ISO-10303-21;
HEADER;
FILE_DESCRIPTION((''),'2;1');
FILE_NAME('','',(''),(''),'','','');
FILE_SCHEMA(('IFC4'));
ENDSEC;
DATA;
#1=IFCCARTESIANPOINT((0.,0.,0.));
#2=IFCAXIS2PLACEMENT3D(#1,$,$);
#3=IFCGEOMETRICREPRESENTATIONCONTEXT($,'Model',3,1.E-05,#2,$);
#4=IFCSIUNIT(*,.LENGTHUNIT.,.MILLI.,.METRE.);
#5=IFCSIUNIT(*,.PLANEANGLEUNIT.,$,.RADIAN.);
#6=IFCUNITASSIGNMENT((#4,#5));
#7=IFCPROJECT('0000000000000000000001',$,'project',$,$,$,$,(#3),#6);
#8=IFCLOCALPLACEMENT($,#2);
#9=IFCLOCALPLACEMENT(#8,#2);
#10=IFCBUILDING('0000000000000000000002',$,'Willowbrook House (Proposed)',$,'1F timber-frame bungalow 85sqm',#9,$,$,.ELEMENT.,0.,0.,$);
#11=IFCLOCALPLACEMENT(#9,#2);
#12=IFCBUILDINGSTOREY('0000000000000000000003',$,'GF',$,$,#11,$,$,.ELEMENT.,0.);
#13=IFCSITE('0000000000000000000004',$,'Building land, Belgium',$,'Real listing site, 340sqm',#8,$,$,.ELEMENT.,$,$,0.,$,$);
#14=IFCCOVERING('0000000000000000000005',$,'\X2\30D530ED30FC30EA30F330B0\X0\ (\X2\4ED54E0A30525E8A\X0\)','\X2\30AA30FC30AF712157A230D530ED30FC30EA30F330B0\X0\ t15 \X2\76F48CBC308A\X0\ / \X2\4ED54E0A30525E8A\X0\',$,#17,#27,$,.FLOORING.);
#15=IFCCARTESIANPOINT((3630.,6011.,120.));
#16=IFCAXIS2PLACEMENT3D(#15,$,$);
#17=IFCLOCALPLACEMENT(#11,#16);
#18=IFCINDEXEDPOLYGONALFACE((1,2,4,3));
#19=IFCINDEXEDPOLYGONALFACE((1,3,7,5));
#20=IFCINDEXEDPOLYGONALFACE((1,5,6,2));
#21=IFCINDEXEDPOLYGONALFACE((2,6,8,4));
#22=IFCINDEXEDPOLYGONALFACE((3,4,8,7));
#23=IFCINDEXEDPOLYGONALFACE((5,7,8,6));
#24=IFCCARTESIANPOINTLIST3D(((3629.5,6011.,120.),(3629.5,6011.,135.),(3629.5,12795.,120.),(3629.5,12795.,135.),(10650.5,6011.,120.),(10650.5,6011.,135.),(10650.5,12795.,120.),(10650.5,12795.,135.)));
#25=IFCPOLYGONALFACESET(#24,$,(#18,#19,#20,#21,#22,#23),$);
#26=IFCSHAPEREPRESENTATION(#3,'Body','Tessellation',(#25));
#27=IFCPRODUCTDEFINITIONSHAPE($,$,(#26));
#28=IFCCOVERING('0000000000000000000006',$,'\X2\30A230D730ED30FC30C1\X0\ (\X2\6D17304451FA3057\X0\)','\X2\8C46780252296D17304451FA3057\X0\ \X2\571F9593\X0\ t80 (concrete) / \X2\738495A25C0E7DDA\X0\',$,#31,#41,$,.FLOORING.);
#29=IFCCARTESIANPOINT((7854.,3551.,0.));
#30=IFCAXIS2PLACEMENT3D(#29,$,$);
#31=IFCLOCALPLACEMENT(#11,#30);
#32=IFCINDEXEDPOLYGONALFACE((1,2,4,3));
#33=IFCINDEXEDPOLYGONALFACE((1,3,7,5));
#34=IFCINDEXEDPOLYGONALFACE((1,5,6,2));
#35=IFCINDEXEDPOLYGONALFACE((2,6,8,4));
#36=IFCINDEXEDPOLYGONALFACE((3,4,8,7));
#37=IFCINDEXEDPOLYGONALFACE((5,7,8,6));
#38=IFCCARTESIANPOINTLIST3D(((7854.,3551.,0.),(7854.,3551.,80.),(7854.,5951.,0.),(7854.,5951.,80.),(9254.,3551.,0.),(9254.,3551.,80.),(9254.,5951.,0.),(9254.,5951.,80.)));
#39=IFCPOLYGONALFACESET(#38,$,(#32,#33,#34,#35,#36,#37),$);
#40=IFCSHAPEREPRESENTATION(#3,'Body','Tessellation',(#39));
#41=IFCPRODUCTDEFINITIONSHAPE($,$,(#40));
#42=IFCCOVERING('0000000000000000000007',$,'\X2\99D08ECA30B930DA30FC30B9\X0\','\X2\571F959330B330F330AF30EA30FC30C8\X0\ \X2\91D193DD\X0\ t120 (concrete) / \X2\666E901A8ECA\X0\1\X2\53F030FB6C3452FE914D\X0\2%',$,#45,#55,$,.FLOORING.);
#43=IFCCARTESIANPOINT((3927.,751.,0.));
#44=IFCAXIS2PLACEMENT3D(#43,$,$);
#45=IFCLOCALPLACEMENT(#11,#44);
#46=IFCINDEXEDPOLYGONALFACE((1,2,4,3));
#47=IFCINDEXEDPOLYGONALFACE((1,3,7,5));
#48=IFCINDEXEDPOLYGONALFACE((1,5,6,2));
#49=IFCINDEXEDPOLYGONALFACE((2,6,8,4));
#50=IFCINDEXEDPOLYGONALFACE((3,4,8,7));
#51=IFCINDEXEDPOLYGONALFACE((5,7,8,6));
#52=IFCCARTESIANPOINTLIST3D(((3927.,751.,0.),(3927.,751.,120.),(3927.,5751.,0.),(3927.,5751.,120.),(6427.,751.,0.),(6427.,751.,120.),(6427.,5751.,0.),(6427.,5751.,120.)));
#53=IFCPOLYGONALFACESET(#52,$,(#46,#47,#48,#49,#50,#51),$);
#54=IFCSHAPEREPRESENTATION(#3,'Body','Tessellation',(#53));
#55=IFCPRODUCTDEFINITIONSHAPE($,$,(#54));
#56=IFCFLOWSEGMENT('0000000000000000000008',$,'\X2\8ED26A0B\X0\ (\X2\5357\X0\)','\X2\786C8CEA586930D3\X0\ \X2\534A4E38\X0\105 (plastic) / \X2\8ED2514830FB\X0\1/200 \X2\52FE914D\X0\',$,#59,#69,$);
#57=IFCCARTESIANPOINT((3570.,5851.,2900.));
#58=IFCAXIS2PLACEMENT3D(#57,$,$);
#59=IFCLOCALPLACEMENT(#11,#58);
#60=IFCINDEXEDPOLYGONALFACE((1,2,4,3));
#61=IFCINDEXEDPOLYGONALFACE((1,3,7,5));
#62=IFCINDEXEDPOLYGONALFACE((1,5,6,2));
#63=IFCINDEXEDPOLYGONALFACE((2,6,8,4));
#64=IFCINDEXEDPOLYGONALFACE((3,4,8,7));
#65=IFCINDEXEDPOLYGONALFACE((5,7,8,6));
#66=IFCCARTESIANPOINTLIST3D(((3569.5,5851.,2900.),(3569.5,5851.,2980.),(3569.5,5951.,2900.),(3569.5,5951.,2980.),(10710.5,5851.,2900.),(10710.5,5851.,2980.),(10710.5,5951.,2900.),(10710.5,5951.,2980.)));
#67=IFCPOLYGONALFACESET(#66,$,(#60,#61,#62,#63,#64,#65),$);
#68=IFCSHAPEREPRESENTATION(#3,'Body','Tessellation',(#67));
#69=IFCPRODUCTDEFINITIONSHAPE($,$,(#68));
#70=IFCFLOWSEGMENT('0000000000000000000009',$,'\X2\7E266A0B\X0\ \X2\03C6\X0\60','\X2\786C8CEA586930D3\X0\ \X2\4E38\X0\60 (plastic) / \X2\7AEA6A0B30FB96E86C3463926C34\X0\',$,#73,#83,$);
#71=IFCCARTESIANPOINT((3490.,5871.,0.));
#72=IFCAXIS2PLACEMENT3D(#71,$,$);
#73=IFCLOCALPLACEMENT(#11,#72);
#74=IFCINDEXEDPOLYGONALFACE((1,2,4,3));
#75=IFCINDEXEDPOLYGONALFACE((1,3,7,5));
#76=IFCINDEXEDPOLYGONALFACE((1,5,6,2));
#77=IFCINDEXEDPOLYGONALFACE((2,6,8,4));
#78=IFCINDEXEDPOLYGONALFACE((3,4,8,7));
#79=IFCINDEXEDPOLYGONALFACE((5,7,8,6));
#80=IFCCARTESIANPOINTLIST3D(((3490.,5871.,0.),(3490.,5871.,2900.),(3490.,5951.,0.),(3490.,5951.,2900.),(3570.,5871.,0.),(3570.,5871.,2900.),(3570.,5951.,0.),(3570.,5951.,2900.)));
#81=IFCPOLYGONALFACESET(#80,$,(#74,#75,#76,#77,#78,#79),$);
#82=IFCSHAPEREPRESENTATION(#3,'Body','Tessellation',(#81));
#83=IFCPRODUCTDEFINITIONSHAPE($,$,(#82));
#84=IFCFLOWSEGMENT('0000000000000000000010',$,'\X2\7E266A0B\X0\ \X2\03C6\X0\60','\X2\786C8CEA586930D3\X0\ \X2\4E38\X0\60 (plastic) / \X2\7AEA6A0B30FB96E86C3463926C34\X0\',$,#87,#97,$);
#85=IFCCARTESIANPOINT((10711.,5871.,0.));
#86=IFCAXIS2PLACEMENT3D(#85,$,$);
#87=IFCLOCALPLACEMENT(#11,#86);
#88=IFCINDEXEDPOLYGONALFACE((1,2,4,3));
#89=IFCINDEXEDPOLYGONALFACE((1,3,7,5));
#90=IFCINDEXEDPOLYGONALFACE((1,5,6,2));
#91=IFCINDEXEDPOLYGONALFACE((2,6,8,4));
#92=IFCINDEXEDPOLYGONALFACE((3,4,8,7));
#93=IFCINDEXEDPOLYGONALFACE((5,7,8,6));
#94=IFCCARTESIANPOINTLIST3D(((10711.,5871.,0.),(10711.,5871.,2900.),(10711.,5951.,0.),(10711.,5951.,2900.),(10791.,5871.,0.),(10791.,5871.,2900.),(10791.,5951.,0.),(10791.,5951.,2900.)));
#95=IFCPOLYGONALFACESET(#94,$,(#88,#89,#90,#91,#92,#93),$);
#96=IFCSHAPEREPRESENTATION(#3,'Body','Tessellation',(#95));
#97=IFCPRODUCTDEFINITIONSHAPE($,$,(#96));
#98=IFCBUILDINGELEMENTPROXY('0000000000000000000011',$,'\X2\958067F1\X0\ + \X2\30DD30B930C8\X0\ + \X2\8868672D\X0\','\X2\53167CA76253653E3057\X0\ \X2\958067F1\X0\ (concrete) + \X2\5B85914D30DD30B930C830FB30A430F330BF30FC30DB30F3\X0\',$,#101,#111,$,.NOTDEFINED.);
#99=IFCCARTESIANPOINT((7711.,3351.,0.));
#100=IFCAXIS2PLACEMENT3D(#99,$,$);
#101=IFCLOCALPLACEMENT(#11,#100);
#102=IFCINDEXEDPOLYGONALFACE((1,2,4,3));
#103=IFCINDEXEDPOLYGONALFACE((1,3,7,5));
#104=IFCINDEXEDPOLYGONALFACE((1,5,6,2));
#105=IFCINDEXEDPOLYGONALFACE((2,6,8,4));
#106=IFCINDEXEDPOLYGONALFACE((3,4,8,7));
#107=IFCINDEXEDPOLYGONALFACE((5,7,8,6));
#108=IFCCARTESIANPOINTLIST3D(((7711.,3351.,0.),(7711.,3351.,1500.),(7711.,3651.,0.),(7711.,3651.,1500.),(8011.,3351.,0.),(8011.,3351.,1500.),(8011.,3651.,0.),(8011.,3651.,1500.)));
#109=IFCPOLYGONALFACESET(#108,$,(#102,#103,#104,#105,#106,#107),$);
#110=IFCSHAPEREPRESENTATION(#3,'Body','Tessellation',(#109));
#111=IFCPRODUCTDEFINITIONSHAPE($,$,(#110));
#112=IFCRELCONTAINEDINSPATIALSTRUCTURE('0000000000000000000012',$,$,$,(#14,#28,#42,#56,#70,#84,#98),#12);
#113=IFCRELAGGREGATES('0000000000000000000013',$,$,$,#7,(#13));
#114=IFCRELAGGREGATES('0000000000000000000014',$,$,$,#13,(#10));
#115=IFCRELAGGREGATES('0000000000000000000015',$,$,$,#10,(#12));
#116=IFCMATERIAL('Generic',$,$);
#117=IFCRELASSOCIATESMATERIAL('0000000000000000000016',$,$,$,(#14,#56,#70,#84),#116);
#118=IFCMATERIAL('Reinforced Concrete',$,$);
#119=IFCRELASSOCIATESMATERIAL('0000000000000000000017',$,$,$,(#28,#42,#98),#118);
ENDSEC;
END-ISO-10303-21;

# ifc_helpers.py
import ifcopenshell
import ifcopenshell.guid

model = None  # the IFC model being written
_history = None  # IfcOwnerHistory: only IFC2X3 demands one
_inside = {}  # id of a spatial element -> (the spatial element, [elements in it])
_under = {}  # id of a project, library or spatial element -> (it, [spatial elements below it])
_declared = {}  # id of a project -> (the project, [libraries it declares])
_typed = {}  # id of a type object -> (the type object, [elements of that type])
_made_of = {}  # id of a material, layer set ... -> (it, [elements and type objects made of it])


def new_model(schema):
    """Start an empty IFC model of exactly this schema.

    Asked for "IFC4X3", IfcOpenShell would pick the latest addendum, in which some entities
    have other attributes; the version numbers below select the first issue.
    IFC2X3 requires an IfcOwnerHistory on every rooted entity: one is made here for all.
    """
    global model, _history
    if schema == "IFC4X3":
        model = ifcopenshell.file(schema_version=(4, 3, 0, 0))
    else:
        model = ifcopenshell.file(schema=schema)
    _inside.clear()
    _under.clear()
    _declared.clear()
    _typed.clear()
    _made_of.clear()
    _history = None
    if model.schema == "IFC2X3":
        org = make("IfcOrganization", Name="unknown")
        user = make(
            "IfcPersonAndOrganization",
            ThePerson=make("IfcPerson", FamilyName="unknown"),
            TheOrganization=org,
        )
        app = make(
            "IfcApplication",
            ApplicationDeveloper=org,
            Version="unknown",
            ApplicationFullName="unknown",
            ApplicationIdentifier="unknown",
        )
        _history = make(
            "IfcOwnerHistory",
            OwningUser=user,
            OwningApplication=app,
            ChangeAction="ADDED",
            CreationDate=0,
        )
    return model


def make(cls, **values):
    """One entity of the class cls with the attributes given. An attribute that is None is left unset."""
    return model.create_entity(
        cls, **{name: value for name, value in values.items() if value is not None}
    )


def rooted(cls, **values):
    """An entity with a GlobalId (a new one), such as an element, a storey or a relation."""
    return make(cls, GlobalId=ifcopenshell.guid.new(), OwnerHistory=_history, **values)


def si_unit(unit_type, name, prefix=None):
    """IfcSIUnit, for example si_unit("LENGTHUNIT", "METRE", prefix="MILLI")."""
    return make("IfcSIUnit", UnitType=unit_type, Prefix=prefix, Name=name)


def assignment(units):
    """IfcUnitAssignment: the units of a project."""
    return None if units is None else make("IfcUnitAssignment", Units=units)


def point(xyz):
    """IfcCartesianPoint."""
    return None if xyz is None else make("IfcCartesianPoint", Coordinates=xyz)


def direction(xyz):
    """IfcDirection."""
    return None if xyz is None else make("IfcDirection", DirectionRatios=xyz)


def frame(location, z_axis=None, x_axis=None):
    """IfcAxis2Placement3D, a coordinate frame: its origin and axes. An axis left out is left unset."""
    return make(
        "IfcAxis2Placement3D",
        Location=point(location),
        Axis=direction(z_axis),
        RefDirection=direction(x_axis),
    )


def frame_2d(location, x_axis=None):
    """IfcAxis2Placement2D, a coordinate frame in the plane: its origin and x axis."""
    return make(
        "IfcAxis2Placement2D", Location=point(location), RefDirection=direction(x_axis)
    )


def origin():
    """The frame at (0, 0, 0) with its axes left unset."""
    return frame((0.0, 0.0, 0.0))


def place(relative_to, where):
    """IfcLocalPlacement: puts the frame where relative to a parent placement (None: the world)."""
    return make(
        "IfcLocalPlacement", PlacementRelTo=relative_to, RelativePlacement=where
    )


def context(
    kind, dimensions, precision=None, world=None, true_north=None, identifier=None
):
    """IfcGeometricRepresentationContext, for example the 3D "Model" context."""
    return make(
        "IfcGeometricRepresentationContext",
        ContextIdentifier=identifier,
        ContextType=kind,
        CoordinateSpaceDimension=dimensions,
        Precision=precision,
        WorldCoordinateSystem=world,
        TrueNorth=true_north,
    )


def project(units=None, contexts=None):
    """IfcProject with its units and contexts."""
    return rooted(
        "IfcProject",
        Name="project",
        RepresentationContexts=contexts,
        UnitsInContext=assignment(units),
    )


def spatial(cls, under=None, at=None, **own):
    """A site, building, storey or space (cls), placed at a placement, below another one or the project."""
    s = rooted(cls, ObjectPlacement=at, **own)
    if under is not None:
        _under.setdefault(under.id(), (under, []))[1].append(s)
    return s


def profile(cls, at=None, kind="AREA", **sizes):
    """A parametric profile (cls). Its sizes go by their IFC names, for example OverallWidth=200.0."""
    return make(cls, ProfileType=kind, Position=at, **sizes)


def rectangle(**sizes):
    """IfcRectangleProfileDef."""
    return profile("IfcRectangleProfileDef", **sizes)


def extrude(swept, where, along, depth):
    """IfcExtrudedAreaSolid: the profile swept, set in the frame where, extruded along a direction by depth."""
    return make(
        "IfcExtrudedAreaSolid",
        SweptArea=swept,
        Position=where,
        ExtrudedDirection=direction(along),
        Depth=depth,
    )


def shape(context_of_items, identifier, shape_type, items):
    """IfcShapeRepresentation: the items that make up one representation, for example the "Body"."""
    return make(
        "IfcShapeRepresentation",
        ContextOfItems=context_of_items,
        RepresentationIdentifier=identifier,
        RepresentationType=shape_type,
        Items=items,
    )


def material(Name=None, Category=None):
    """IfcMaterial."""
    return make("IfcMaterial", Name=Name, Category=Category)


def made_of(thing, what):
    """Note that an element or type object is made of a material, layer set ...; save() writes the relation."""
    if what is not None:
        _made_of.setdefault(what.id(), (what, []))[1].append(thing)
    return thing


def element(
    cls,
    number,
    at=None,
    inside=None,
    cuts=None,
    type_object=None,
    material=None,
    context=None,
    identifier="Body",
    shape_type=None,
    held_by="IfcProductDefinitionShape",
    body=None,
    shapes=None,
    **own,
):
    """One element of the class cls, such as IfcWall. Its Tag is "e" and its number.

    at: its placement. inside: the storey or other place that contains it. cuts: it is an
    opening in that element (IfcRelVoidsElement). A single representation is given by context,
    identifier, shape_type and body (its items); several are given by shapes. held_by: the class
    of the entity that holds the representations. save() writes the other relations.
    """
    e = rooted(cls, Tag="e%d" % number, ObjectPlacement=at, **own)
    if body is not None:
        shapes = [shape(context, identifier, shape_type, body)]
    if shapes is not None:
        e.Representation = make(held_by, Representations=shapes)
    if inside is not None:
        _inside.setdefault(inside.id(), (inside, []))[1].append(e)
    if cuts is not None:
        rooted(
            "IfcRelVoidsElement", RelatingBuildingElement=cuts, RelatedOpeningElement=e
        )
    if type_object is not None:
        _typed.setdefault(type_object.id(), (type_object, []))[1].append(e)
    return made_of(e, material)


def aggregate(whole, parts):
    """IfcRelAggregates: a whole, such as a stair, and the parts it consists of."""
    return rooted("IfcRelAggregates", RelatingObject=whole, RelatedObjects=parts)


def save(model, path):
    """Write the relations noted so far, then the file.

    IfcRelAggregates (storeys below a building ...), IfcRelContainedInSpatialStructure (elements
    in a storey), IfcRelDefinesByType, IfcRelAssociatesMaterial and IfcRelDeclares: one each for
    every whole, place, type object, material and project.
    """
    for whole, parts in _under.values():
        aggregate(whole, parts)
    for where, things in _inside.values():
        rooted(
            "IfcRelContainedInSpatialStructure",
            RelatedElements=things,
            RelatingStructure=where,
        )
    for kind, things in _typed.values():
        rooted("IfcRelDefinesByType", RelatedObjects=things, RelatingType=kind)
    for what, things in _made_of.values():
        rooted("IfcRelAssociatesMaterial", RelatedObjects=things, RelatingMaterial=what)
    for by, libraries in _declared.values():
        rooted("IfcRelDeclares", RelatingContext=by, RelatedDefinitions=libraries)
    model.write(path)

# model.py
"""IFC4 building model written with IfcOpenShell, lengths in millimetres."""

from ifc_helpers import new_model, si_unit, frame, frame_2d, origin, place, context, project, spatial, rectangle, extrude, material, element, save


model = new_model("IFC4")

# Units and contexts
model_context = context("Model", 3, precision=1e-05, world=origin())
ifc_project = project(units=[si_unit("LENGTHUNIT", "METRE", prefix="MILLI"), si_unit("PLANEANGLEUNIT", "RADIAN")], contexts=[model_context])

# Site, building, storey
site_placement = place(None, origin())
site = spatial("IfcSite", under=ifc_project, at=site_placement, Name="Building land, Belgium", ObjectType="Real listing site, 340sqm", CompositionType="ELEMENT", RefElevation=0.0)
building_placement = place(site_placement, origin())
building = spatial("IfcBuilding", under=site, at=building_placement, Name="Willowbrook House (Proposed)", ObjectType="1F timber-frame bungalow 85sqm", CompositionType="ELEMENT", ElevationOfRefHeight=0.0, ElevationOfTerrain=0.0)
storey_placement = place(building_placement, origin())
storey = spatial("IfcBuildingStorey", under=building, at=storey_placement, Name="GF", CompositionType="ELEMENT", Elevation=0.0)

# Shared definitions
ifc_material_1 = material(Name="Reinforced Concrete")

# Coverings
ifc_material_2 = material(Name="Generic")
covering_1_placement = place(storey_placement, frame((3630.0, 6011.0, 120.0)))
element("IfcCovering", 1, at=covering_1_placement, inside=storey, material=ifc_material_2, Name="フローリング (仕上げ床)", Description="オーク無垢フローリング t15 直貼り / 仕上げ床", PredefinedType="FLOORING", context=model_context, shape_type="SweptSolid", body=[
    extrude(rectangle(XDim=7021.0, YDim=6784.0, at=frame_2d((3510.0, 3392.0))), frame((3630.0, 6011.0, 120.0)), (0.0, 0.0, 1.0), 15.0),
])
covering_2_placement = place(storey_placement, frame((7854.0, 3551.0, 0.0)))
element("IfcCovering", 2, at=covering_2_placement, inside=storey, material=ifc_material_1, Name="アプローチ (洗い出し)", Description="豆砂利洗い出し 土間 t80 (concrete) / 玄関導線", PredefinedType="FLOORING", context=model_context, shape_type="SweptSolid", body=[
    extrude(rectangle(XDim=1400.0, YDim=2400.0, at=frame_2d((700.0, 1200.0))), frame((7854.0, 3551.0, 0.0)), (0.0, 0.0, 1.0), 80.0),
])
covering_3_placement = place(storey_placement, frame((3927.0, 751.0, 0.0)))
element("IfcCovering", 3, at=covering_3_placement, inside=storey, material=ifc_material_1, Name="駐車スペース", Description="土間コンクリート 金鏝 t120 (concrete) / 普通車1台・水勾配2%", PredefinedType="FLOORING", context=model_context, shape_type="SweptSolid", body=[
    extrude(rectangle(XDim=2500.0, YDim=5000.0, at=frame_2d((1250.0, 2500.0))), frame((3927.0, 751.0, 0.0)), (0.0, 0.0, 1.0), 120.0),
])

# Flow segments
flow_segment_1_placement = place(storey_placement, frame((3570.0, 5851.0, 2900.0)))
element("IfcFlowSegment", 4, at=flow_segment_1_placement, inside=storey, material=ifc_material_2, Name="軒樋 (南)", Description="硬質塩ビ 半丸105 (plastic) / 軒先・1/200 勾配", context=model_context, shape_type="SweptSolid", body=[
    extrude(rectangle(XDim=7141.0, YDim=100.0, at=frame_2d((3570.0, 50.0))), frame((3570.0, 5851.0, 2900.0)), (0.0, 0.0, 1.0), 80.0),
])
flow_segment_2_placement = place(storey_placement, frame((3490.0, 5871.0, 0.0)))
element("IfcFlowSegment", 5, at=flow_segment_2_placement, inside=storey, material=ifc_material_2, Name="縦樋 φ60", Description="硬質塩ビ 丸60 (plastic) / 竪樋・雨水排水", context=model_context, shape_type="SweptSolid", body=[
    extrude(rectangle(XDim=80.0, YDim=80.0, at=frame_2d((40.0, 40.0))), frame((3490.0, 5871.0, 0.0)), (0.0, 0.0, 1.0), 2900.0),
])
flow_segment_3_placement = place(storey_placement, frame((10711.0, 5871.0, 0.0)))
element("IfcFlowSegment", 6, at=flow_segment_3_placement, inside=storey, material=ifc_material_2, Name="縦樋 φ60", Description="硬質塩ビ 丸60 (plastic) / 竪樋・雨水排水", context=model_context, shape_type="SweptSolid", body=[
    extrude(rectangle(XDim=80.0, YDim=80.0, at=frame_2d((40.0, 40.0))), frame((10711.0, 5871.0, 0.0)), (0.0, 0.0, 1.0), 2900.0),
])

# Building element proxy
proxy_placement = place(storey_placement, frame((7711.0, 3351.0, 0.0)))
element("IfcBuildingElementProxy", 7, at=proxy_placement, inside=storey, material=ifc_material_1, Name="門柱 + ポスト + 表札", Description="化粧打放し 門柱 (concrete) + 宅配ポスト・インターホン", PredefinedType="NOTDEFINED", context=model_context, shape_type="SweptSolid", body=[
    extrude(rectangle(XDim=300.0, YDim=300.0, at=frame_2d((150.0, 150.0))), frame((7711.0, 3351.0, 0.0)), (0.0, 0.0, 1.0), 1500.0),
])

save(model, "model.ifc")
